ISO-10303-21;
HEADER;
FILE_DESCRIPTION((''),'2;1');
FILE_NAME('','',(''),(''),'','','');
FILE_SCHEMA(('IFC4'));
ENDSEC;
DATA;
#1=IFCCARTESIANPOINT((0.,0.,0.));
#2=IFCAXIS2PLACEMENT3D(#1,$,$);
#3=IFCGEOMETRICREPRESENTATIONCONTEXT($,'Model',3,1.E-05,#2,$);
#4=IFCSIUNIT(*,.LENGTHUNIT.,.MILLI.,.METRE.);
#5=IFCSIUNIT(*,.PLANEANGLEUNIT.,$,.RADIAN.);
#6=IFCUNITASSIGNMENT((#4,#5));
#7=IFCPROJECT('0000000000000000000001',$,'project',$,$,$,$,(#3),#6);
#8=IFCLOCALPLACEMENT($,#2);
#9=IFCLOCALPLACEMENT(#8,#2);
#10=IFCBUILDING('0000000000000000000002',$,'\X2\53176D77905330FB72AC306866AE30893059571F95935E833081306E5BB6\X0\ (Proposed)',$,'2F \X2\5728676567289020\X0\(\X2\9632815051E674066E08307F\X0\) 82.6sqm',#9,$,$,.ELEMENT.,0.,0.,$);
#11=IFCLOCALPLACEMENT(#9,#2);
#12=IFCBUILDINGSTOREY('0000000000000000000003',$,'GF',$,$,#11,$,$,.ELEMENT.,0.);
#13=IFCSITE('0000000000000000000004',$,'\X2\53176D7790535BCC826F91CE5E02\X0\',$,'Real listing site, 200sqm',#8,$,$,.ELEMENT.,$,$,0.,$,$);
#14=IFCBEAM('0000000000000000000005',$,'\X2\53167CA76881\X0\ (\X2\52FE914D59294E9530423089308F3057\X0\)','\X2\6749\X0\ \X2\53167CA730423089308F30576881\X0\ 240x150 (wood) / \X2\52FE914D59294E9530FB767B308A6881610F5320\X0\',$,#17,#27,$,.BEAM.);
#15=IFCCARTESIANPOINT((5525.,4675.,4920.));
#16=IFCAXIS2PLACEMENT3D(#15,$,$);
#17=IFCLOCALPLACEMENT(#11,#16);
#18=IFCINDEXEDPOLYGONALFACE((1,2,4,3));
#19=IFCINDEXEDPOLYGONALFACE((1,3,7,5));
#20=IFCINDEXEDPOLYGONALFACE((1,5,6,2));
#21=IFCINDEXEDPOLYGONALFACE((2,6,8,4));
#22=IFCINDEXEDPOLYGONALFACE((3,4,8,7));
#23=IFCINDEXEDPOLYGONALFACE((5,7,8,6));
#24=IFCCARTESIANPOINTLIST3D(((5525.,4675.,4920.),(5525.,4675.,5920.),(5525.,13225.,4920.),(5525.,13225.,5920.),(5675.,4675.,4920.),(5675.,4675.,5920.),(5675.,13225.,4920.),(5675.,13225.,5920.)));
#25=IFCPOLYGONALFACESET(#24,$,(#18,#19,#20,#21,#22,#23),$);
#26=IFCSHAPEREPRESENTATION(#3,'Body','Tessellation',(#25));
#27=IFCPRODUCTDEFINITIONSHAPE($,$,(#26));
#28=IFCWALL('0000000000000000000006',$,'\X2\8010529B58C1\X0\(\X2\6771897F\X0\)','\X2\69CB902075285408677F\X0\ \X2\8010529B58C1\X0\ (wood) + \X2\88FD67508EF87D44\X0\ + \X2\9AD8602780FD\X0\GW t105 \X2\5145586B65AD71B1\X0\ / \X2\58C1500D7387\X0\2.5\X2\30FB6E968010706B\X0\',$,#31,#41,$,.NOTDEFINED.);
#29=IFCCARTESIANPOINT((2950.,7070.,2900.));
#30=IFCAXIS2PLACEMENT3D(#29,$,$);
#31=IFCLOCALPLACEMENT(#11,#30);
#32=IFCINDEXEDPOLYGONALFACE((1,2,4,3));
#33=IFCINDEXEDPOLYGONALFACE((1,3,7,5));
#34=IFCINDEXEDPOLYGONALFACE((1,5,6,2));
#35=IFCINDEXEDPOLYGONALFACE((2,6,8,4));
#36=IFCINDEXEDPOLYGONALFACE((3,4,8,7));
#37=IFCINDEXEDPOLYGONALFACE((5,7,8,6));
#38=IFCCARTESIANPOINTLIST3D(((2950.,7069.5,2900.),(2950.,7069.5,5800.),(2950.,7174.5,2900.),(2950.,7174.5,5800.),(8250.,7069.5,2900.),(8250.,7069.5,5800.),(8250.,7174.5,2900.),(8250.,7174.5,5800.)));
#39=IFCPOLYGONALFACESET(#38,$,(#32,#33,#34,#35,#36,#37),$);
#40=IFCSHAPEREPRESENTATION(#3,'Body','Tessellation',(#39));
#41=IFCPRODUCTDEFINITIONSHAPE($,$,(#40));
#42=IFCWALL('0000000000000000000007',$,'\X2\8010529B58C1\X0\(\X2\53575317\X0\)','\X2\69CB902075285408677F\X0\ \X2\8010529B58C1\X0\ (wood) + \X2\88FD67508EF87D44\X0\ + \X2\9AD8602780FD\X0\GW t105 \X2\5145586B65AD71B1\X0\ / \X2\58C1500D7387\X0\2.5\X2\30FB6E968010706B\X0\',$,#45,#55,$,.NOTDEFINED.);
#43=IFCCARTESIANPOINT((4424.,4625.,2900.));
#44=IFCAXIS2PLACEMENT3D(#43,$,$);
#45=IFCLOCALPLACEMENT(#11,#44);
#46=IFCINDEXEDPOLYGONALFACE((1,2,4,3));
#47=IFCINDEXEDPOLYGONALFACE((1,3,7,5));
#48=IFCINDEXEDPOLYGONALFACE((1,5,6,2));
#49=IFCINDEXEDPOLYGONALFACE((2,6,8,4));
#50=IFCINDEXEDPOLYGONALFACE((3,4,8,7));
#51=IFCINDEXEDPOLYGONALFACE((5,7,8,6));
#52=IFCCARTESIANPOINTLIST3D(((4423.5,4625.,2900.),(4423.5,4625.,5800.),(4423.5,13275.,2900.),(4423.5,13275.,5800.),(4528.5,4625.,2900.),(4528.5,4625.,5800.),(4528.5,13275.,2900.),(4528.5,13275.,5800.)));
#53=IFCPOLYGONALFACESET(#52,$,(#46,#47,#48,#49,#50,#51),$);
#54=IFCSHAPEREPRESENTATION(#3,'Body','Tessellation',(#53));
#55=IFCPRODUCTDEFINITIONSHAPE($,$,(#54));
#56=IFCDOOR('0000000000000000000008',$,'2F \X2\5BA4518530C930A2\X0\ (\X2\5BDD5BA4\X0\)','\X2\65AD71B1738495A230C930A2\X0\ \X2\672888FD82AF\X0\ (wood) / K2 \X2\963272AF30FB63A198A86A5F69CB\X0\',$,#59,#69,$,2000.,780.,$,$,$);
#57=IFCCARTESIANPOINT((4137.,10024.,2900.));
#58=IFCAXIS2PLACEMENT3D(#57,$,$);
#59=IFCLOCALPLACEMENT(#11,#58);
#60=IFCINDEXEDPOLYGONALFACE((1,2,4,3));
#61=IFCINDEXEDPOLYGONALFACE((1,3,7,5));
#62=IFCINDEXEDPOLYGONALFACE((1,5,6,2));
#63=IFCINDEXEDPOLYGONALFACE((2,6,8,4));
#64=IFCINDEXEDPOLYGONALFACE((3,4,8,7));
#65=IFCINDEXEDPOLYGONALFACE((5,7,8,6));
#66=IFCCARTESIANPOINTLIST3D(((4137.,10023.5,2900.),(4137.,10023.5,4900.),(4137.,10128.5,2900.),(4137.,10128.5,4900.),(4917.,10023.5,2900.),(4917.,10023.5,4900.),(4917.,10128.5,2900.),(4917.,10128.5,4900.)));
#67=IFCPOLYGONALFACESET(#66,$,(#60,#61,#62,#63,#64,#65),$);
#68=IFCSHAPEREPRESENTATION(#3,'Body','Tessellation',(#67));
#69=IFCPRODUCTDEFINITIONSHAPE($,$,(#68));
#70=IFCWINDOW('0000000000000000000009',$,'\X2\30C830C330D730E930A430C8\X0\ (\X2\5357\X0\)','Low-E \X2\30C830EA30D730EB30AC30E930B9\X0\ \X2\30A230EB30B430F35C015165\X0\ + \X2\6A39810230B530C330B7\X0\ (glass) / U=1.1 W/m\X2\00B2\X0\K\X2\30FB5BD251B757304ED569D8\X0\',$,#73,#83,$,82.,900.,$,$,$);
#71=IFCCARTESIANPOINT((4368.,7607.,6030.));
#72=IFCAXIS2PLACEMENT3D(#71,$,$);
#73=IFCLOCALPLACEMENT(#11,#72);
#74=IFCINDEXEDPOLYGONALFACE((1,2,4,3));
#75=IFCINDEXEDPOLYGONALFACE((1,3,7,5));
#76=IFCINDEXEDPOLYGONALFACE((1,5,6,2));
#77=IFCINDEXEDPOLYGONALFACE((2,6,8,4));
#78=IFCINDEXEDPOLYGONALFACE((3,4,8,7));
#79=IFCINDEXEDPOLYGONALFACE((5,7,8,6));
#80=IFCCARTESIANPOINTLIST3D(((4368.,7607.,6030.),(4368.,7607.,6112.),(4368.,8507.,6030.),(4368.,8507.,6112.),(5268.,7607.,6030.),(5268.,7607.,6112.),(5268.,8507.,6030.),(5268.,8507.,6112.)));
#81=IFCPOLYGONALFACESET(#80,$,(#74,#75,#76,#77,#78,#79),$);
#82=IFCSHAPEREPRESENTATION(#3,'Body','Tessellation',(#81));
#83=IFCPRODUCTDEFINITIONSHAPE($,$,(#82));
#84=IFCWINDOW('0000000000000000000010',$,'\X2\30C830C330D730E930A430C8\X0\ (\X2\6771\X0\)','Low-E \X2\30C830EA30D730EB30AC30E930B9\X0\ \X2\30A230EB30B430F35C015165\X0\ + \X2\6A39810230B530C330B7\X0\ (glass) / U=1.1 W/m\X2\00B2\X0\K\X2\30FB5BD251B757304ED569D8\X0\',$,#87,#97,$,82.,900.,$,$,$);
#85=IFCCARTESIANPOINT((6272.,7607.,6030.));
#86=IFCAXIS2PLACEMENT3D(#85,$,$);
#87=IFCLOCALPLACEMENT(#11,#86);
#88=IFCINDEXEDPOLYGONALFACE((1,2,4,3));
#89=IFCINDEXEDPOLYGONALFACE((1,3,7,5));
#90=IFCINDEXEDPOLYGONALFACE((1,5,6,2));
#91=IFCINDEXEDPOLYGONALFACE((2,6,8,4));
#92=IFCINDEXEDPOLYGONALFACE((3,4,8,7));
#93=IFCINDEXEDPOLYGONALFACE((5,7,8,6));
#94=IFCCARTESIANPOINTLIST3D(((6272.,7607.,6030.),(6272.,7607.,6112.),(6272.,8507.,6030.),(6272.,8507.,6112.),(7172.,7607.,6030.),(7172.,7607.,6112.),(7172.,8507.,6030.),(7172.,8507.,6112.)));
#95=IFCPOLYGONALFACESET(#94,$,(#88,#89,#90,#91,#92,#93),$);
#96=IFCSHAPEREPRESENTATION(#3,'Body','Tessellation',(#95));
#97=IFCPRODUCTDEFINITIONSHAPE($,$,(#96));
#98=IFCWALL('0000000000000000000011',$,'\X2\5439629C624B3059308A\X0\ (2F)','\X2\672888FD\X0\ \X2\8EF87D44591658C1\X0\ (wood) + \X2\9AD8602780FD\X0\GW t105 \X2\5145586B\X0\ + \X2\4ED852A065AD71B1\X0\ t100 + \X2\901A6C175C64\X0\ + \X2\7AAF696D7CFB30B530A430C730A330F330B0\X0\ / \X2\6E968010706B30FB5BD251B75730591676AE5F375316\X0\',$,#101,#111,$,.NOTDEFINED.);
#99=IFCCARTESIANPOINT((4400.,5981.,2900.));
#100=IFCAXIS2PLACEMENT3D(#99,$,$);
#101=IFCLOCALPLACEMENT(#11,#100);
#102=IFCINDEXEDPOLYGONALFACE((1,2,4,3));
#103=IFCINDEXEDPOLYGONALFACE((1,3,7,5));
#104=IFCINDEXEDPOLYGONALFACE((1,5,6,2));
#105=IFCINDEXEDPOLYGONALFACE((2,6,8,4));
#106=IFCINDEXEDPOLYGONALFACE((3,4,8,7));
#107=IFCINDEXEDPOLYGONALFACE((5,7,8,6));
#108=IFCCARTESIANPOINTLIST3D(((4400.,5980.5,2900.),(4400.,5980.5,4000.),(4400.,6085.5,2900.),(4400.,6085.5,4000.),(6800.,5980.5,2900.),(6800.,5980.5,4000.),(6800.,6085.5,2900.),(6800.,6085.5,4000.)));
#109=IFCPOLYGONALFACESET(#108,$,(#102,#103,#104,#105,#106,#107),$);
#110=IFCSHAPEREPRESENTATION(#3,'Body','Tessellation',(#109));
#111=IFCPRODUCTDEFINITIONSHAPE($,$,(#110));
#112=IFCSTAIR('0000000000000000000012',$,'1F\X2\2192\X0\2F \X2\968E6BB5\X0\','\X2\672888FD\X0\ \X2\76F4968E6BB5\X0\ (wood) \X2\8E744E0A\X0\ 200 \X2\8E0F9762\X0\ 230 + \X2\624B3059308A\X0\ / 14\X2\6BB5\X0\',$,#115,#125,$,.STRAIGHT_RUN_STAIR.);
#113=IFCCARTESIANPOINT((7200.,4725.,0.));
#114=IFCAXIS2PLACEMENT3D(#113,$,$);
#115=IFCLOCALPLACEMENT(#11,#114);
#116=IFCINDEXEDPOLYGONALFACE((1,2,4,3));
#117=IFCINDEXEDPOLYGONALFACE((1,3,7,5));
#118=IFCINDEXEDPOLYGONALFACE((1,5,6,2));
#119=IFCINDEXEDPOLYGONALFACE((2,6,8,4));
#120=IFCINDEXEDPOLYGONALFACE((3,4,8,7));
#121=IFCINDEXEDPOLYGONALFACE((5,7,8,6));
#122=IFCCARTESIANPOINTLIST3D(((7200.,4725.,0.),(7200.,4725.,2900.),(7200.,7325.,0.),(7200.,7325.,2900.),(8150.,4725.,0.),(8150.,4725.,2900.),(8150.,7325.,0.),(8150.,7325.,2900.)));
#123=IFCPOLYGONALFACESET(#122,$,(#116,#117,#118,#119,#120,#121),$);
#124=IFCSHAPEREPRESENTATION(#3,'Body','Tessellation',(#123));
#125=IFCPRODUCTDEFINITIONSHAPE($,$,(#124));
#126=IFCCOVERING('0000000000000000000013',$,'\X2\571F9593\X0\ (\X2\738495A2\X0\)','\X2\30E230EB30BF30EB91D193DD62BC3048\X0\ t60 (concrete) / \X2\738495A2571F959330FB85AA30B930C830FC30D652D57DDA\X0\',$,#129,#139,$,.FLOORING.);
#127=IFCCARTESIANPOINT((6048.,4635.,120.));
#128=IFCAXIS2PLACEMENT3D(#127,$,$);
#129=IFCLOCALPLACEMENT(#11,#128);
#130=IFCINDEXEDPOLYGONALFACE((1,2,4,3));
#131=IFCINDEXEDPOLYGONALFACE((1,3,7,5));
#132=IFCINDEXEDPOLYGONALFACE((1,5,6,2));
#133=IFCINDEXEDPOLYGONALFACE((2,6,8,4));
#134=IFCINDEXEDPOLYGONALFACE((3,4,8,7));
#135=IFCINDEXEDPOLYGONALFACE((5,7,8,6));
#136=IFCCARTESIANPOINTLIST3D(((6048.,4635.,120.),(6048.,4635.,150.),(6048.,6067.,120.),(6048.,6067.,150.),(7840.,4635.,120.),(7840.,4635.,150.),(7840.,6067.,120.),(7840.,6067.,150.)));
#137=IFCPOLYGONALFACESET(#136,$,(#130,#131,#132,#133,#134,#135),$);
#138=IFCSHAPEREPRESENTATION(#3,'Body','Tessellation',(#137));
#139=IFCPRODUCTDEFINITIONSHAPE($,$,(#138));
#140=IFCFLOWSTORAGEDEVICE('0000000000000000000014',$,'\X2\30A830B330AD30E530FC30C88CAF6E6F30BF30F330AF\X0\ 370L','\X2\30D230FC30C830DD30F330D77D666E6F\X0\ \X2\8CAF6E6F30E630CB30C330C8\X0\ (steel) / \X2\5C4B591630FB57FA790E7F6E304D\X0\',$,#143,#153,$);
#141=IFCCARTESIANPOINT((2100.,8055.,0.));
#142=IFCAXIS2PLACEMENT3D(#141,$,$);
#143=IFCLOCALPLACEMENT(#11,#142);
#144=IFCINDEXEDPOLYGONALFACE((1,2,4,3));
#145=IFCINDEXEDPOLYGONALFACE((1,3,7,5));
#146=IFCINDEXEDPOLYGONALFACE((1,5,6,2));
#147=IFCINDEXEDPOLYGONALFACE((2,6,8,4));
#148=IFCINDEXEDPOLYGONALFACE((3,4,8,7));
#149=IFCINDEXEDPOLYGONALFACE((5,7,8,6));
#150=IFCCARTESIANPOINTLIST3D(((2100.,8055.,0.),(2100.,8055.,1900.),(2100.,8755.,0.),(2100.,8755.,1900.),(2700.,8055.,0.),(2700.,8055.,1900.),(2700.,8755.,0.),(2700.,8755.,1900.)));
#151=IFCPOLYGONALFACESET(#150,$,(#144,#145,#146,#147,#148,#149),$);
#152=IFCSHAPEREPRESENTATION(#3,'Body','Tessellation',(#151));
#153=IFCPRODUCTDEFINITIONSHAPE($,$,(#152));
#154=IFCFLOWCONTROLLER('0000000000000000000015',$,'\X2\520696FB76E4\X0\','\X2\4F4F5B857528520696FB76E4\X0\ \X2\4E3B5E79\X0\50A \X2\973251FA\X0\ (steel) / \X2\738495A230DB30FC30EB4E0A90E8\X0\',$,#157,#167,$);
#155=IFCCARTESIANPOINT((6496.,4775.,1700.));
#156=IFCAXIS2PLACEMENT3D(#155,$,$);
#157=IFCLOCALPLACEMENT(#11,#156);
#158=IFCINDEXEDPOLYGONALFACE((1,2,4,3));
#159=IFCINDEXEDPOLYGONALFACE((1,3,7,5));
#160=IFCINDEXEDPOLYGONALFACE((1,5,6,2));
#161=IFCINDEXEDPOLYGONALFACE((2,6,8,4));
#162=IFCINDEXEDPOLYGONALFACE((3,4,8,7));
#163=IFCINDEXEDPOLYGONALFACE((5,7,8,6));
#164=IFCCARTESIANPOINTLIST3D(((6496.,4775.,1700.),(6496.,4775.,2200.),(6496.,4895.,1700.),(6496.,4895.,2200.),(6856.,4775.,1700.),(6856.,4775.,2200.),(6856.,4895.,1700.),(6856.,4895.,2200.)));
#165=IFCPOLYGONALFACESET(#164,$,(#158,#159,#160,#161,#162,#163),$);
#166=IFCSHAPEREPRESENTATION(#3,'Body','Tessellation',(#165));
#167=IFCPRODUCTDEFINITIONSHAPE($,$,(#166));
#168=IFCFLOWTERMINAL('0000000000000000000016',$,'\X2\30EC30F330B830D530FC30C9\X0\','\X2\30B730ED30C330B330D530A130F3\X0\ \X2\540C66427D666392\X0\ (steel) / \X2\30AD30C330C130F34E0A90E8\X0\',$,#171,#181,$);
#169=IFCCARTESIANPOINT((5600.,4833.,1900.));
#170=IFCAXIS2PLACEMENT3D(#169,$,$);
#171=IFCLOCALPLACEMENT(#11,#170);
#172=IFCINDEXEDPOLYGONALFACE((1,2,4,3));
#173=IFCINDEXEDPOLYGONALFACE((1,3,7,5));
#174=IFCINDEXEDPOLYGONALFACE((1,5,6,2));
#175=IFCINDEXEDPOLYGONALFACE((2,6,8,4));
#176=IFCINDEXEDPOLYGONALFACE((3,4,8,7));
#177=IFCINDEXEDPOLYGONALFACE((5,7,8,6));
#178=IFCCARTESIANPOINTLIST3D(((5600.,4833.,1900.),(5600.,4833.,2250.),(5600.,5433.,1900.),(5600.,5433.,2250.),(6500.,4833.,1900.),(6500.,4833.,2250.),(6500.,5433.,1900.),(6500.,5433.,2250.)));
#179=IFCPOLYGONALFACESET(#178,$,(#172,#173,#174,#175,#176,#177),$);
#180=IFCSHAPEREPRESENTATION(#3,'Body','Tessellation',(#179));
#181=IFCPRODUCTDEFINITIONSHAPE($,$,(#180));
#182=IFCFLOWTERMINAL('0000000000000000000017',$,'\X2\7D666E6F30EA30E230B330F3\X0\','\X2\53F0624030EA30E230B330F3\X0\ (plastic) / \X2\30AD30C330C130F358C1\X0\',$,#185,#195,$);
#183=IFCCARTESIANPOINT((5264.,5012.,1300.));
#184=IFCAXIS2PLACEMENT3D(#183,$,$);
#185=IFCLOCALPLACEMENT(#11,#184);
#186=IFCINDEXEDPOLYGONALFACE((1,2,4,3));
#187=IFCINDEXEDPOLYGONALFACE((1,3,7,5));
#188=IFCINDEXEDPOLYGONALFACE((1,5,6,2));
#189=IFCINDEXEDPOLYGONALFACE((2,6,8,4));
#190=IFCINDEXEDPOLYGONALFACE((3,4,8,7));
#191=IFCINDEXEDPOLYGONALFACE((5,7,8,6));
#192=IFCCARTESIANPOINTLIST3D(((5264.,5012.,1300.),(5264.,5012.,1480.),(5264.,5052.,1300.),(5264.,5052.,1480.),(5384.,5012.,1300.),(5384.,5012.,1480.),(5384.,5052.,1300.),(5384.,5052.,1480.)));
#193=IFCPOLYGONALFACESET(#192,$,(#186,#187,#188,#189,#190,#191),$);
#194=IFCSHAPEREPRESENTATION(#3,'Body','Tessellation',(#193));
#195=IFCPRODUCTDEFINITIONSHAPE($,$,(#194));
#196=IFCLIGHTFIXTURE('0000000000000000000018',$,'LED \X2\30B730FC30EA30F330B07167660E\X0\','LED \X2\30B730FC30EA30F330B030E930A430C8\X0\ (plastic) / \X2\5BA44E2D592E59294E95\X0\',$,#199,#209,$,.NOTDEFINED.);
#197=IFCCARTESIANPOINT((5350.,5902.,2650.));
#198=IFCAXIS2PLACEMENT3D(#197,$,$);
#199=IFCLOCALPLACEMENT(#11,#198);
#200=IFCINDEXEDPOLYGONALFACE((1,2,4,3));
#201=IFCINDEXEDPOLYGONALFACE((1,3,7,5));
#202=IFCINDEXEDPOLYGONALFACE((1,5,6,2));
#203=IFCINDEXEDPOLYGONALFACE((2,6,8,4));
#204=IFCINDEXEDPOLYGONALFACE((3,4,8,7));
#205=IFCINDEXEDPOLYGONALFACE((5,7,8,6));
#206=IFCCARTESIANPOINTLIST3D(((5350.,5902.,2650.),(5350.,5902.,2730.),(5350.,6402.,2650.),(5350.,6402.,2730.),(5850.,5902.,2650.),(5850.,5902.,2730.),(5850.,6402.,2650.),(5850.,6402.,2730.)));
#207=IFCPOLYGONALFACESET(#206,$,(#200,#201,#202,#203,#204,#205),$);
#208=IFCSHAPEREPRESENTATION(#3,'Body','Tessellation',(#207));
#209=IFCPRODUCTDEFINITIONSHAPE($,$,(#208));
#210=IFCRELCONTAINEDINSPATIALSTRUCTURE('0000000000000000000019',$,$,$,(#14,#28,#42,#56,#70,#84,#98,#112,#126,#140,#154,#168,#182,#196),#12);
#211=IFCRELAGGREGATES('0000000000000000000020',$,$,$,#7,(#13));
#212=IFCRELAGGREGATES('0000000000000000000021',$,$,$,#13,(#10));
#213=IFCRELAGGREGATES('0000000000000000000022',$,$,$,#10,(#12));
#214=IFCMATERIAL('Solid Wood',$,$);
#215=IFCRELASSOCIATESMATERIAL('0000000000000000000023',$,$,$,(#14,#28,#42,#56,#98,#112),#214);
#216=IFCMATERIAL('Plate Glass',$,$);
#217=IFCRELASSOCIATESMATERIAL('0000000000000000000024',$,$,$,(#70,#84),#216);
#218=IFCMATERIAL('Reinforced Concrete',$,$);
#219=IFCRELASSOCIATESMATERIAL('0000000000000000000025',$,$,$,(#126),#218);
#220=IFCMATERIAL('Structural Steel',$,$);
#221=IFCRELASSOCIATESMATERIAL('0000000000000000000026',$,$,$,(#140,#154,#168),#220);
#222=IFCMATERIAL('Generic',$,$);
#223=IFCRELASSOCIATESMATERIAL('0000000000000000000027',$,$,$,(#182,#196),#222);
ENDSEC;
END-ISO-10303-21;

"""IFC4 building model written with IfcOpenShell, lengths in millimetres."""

from ifc_helpers import new_model, si_unit, frame, frame_2d, origin, place, context, project, spatial, rectangle, extrude, material, element, fill, save


model = new_model("IFC4")

# Units and contexts
model_context = context("Model", 3, precision=1e-05, world=origin())
ifc_project = project(units=[si_unit("LENGTHUNIT", "METRE", prefix="MILLI"), si_unit("PLANEANGLEUNIT", "RADIAN")], contexts=[model_context])

# Site, building, storey
site_placement = place(None, origin())
site = spatial("IfcSite", under=ifc_project, at=site_placement, Name="北海道富良野市", ObjectType="Real listing site, 200sqm", CompositionType="ELEMENT", RefElevation=0.0)
building_placement = place(site_placement, origin())
building = spatial("IfcBuilding", under=site, at=building_placement, Name="北海道・犬と暮らす土間広めの家 (Proposed)", ObjectType="2F 在来木造(防腐処理済み) 82.6sqm", CompositionType="ELEMENT", ElevationOfRefHeight=0.0, ElevationOfTerrain=0.0)
storey_placement = place(building_placement, origin())
storey = spatial("IfcBuildingStorey", under=building, at=storey_placement, Name="GF", CompositionType="ELEMENT", Elevation=0.0)

# Shared definitions
ifc_material_1 = material(Name="Solid Wood")

# Beam
beam_placement = place(storey_placement, frame((5525.0, 4675.0, 4920.0)))
element("IfcBeam", 1, at=beam_placement, inside=storey, material=ifc_material_1, Name="化粧梁 (勾配天井あらわし)", Description="杉 化粧あらわし梁 240x150 (wood) / 勾配天井・登り梁意匠", PredefinedType="BEAM", context=model_context, shape_type="SweptSolid", body=[
    extrude(rectangle(XDim=150.0, YDim=8550.0, at=frame_2d((75.0, 4275.0))), frame((5525.0, 4675.0, 4920.0)), (0.0, 0.0, 1.0), 1000.0),
])

# Wall
wall_1_placement = place(storey_placement, frame((2950.0, 7070.0, 2900.0)))
element("IfcWall", 2, at=wall_1_placement, inside=storey, material=ifc_material_1, Name="耐力壁(東西)", Description="構造用合板 耐力壁 (wood) + 製材軸組 + 高性能GW t105 充填断熱 / 壁倍率2.5・準耐火", PredefinedType="NOTDEFINED", context=model_context, shape_type="SweptSolid", body=[
    extrude(rectangle(XDim=5300.0, YDim=105.0, at=frame_2d((2650.0, 52.0))), frame((2950.0, 7070.0, 2900.0)), (0.0, 0.0, 1.0), 2900.0),
])

# Wall, opening, door
wall_2_placement = place(storey_placement, frame((4424.0, 4625.0, 2900.0)))
wall_2 = element("IfcWall", 3, at=wall_2_placement, inside=storey, material=ifc_material_1, Name="耐力壁(南北)", Description="構造用合板 耐力壁 (wood) + 製材軸組 + 高性能GW t105 充填断熱 / 壁倍率2.5・準耐火", PredefinedType="NOTDEFINED", context=model_context, shape_type="SweptSolid", body=[
    extrude(rectangle(XDim=105.0, YDim=8650.0, at=frame_2d((52.0, 4325.0))), frame((4424.0, 4625.0, 2900.0)), (0.0, 0.0, 1.0), 2900.0),
])
opening_placement = place(storey_placement, frame((4137.0, 10024.0, 2900.0)))
opening = element("IfcOpeningElement", 4, at=opening_placement, cuts=wall_2, PredefinedType="NOTDEFINED", context=model_context, shape_type="SweptSolid", body=[
    extrude(rectangle(XDim=780.0, YDim=105.0, at=frame_2d((390.0, 52.0))), frame((4137.0, 10024.0, 2900.0)), (0.0, 0.0, 1.0), 2000.0),
])
door_placement = place(storey_placement, frame((4137.0, 10024.0, 2900.0)))
door = element("IfcDoor", 5, at=door_placement, inside=storey, material=ifc_material_1, Name="2F 室内ドア (寝室)", Description="断熱玄関ドア 木製芯 (wood) / K2 防犯・採風機構", OverallHeight=2000.0, OverallWidth=780.0, context=model_context, shape_type="SweptSolid", body=[
    extrude(rectangle(XDim=780.0, YDim=105.0, at=frame_2d((390.0, 52.0))), frame((4137.0, 10024.0, 2900.0)), (0.0, 0.0, 1.0), 2000.0),
])
fill(opening, door)

# Windows
ifc_material_2 = material(Name="Plate Glass")
window_1_placement = place(storey_placement, frame((4368.0, 7607.0, 6030.0)))
element("IfcWindow", 6, at=window_1_placement, inside=storey, material=ifc_material_2, Name="トップライト (南)", Description="Low-E トリプルガラス アルゴン封入 + 樹脂サッシ (glass) / U=1.1 W/m²K・寒冷地仕様", OverallHeight=82.0, OverallWidth=900.0, context=model_context, shape_type="SweptSolid", body=[
    extrude(rectangle(XDim=900.0, YDim=900.0, at=frame_2d((450.0, 450.0))), frame((4368.0, 7607.0, 6030.0)), (0.0, 0.0, 1.0), 82.0),
])
window_2_placement = place(storey_placement, frame((6272.0, 7607.0, 6030.0)))
element("IfcWindow", 7, at=window_2_placement, inside=storey, material=ifc_material_2, Name="トップライト (東)", Description="Low-E トリプルガラス アルゴン封入 + 樹脂サッシ (glass) / U=1.1 W/m²K・寒冷地仕様", OverallHeight=82.0, OverallWidth=900.0, context=model_context, shape_type="SweptSolid", body=[
    extrude(rectangle(XDim=900.0, YDim=900.0, at=frame_2d((450.0, 450.0))), frame((6272.0, 7607.0, 6030.0)), (0.0, 0.0, 1.0), 82.0),
])

# Wall
wall_3_placement = place(storey_placement, frame((4400.0, 5981.0, 2900.0)))
element("IfcWall", 8, at=wall_3_placement, inside=storey, material=ifc_material_1, Name="吹抜手すり (2F)", Description="木製 軸組外壁 (wood) + 高性能GW t105 充填 + 付加断熱 t100 + 通気層 + 窯業系サイディング / 準耐火・寒冷地外皮強化", PredefinedType="NOTDEFINED", context=model_context, shape_type="SweptSolid", body=[
    extrude(rectangle(XDim=2400.0, YDim=105.0, at=frame_2d((1200.0, 52.0))), frame((4400.0, 5981.0, 2900.0)), (0.0, 0.0, 1.0), 1100.0),
])

# Stair
stair_placement = place(storey_placement, frame((7200.0, 4725.0, 0.0)))
element("IfcStair", 9, at=stair_placement, inside=storey, material=ifc_material_1, Name="1F→2F 階段", Description="木製 直階段 (wood) 蹴上 200 踏面 230 + 手すり / 14段", PredefinedType="STRAIGHT_RUN_STAIR", context=model_context, shape_type="SweptSolid", body=[
    extrude(rectangle(XDim=950.0, YDim=2600.0, at=frame_2d((475.0, 1300.0))), frame((7200.0, 4725.0, 0.0)), (0.0, 0.0, 1.0), 2900.0),
])

# Covering
ifc_material_3 = material(Name="Reinforced Concrete")
covering_placement = place(storey_placement, frame((6048.0, 4635.0, 120.0)))
element("IfcCovering", 10, at=covering_placement, inside=storey, material=ifc_material_3, Name="土間 (玄関)", Description="モルタル金鏝押え t60 (concrete) / 玄関土間・薪ストーブ動線", PredefinedType="FLOORING", context=model_context, shape_type="SweptSolid", body=[
    extrude(rectangle(XDim=1792.0, YDim=1432.0, at=frame_2d((896.0, 716.0))), frame((6048.0, 4635.0, 120.0)), (0.0, 0.0, 1.0), 30.0),
])

# Flow storage device
ifc_material_4 = material(Name="Structural Steel")
flow_storage_device_placement = place(storey_placement, frame((2100.0, 8055.0, 0.0)))
element("IfcFlowStorageDevice", 11, at=flow_storage_device_placement, inside=storey, material=ifc_material_4, Name="エコキュート貯湯タンク 370L", Description="ヒートポンプ給湯 貯湯ユニット (steel) / 屋外・基礎置き", context=model_context, shape_type="SweptSolid", body=[
    extrude(rectangle(XDim=600.0, YDim=700.0, at=frame_2d((300.0, 350.0))), frame((2100.0, 8055.0, 0.0)), (0.0, 0.0, 1.0), 1900.0),
])

# Flow controller
flow_controller_placement = place(storey_placement, frame((6496.0, 4775.0, 1700.0)))
element("IfcFlowController", 12, at=flow_controller_placement, inside=storey, material=ifc_material_4, Name="分電盤", Description="住宅用分電盤 主幹50A 露出 (steel) / 玄関ホール上部", context=model_context, shape_type="SweptSolid", body=[
    extrude(rectangle(XDim=360.0, YDim=120.0, at=frame_2d((180.0, 60.0))), frame((6496.0, 4775.0, 1700.0)), (0.0, 0.0, 1.0), 500.0),
])

# Flow terminals
flow_terminal_1_placement = place(storey_placement, frame((5600.0, 4833.0, 1900.0)))
element("IfcFlowTerminal", 13, at=flow_terminal_1_placement, inside=storey, material=ifc_material_4, Name="レンジフード", Description="シロッコファン 同時給排 (steel) / キッチン上部", context=model_context, shape_type="SweptSolid", body=[
    extrude(rectangle(XDim=900.0, YDim=600.0, at=frame_2d((450.0, 300.0))), frame((5600.0, 4833.0, 1900.0)), (0.0, 0.0, 1.0), 350.0),
])
ifc_material_5 = material(Name="Generic")
flow_terminal_2_placement = place(storey_placement, frame((5264.0, 5012.0, 1300.0)))
element("IfcFlowTerminal", 14, at=flow_terminal_2_placement, inside=storey, material=ifc_material_5, Name="給湯リモコン", Description="台所リモコン (plastic) / キッチン壁", context=model_context, shape_type="SweptSolid", body=[
    extrude(rectangle(XDim=120.0, YDim=40.0, at=frame_2d((60.0, 20.0))), frame((5264.0, 5012.0, 1300.0)), (0.0, 0.0, 1.0), 180.0),
])

# Light fixture
light_fixture_1_placement = place(storey_placement, frame((5350.0, 5902.0, 2650.0)))
element("IfcLightFixture", 15, at=light_fixture_1_placement, inside=storey, material=ifc_material_5, Name="LED シーリング照明", Description="LED シーリングライト (plastic) / 室中央天井", PredefinedType="NOTDEFINED", context=model_context, shape_type="SweptSolid", body=[
    extrude(rectangle(XDim=500.0, YDim=500.0, at=frame_2d((250.0, 250.0))), frame((5350.0, 5902.0, 2650.0)), (0.0, 0.0, 1.0), 80.0),
])

save(model, "model.ifc")
